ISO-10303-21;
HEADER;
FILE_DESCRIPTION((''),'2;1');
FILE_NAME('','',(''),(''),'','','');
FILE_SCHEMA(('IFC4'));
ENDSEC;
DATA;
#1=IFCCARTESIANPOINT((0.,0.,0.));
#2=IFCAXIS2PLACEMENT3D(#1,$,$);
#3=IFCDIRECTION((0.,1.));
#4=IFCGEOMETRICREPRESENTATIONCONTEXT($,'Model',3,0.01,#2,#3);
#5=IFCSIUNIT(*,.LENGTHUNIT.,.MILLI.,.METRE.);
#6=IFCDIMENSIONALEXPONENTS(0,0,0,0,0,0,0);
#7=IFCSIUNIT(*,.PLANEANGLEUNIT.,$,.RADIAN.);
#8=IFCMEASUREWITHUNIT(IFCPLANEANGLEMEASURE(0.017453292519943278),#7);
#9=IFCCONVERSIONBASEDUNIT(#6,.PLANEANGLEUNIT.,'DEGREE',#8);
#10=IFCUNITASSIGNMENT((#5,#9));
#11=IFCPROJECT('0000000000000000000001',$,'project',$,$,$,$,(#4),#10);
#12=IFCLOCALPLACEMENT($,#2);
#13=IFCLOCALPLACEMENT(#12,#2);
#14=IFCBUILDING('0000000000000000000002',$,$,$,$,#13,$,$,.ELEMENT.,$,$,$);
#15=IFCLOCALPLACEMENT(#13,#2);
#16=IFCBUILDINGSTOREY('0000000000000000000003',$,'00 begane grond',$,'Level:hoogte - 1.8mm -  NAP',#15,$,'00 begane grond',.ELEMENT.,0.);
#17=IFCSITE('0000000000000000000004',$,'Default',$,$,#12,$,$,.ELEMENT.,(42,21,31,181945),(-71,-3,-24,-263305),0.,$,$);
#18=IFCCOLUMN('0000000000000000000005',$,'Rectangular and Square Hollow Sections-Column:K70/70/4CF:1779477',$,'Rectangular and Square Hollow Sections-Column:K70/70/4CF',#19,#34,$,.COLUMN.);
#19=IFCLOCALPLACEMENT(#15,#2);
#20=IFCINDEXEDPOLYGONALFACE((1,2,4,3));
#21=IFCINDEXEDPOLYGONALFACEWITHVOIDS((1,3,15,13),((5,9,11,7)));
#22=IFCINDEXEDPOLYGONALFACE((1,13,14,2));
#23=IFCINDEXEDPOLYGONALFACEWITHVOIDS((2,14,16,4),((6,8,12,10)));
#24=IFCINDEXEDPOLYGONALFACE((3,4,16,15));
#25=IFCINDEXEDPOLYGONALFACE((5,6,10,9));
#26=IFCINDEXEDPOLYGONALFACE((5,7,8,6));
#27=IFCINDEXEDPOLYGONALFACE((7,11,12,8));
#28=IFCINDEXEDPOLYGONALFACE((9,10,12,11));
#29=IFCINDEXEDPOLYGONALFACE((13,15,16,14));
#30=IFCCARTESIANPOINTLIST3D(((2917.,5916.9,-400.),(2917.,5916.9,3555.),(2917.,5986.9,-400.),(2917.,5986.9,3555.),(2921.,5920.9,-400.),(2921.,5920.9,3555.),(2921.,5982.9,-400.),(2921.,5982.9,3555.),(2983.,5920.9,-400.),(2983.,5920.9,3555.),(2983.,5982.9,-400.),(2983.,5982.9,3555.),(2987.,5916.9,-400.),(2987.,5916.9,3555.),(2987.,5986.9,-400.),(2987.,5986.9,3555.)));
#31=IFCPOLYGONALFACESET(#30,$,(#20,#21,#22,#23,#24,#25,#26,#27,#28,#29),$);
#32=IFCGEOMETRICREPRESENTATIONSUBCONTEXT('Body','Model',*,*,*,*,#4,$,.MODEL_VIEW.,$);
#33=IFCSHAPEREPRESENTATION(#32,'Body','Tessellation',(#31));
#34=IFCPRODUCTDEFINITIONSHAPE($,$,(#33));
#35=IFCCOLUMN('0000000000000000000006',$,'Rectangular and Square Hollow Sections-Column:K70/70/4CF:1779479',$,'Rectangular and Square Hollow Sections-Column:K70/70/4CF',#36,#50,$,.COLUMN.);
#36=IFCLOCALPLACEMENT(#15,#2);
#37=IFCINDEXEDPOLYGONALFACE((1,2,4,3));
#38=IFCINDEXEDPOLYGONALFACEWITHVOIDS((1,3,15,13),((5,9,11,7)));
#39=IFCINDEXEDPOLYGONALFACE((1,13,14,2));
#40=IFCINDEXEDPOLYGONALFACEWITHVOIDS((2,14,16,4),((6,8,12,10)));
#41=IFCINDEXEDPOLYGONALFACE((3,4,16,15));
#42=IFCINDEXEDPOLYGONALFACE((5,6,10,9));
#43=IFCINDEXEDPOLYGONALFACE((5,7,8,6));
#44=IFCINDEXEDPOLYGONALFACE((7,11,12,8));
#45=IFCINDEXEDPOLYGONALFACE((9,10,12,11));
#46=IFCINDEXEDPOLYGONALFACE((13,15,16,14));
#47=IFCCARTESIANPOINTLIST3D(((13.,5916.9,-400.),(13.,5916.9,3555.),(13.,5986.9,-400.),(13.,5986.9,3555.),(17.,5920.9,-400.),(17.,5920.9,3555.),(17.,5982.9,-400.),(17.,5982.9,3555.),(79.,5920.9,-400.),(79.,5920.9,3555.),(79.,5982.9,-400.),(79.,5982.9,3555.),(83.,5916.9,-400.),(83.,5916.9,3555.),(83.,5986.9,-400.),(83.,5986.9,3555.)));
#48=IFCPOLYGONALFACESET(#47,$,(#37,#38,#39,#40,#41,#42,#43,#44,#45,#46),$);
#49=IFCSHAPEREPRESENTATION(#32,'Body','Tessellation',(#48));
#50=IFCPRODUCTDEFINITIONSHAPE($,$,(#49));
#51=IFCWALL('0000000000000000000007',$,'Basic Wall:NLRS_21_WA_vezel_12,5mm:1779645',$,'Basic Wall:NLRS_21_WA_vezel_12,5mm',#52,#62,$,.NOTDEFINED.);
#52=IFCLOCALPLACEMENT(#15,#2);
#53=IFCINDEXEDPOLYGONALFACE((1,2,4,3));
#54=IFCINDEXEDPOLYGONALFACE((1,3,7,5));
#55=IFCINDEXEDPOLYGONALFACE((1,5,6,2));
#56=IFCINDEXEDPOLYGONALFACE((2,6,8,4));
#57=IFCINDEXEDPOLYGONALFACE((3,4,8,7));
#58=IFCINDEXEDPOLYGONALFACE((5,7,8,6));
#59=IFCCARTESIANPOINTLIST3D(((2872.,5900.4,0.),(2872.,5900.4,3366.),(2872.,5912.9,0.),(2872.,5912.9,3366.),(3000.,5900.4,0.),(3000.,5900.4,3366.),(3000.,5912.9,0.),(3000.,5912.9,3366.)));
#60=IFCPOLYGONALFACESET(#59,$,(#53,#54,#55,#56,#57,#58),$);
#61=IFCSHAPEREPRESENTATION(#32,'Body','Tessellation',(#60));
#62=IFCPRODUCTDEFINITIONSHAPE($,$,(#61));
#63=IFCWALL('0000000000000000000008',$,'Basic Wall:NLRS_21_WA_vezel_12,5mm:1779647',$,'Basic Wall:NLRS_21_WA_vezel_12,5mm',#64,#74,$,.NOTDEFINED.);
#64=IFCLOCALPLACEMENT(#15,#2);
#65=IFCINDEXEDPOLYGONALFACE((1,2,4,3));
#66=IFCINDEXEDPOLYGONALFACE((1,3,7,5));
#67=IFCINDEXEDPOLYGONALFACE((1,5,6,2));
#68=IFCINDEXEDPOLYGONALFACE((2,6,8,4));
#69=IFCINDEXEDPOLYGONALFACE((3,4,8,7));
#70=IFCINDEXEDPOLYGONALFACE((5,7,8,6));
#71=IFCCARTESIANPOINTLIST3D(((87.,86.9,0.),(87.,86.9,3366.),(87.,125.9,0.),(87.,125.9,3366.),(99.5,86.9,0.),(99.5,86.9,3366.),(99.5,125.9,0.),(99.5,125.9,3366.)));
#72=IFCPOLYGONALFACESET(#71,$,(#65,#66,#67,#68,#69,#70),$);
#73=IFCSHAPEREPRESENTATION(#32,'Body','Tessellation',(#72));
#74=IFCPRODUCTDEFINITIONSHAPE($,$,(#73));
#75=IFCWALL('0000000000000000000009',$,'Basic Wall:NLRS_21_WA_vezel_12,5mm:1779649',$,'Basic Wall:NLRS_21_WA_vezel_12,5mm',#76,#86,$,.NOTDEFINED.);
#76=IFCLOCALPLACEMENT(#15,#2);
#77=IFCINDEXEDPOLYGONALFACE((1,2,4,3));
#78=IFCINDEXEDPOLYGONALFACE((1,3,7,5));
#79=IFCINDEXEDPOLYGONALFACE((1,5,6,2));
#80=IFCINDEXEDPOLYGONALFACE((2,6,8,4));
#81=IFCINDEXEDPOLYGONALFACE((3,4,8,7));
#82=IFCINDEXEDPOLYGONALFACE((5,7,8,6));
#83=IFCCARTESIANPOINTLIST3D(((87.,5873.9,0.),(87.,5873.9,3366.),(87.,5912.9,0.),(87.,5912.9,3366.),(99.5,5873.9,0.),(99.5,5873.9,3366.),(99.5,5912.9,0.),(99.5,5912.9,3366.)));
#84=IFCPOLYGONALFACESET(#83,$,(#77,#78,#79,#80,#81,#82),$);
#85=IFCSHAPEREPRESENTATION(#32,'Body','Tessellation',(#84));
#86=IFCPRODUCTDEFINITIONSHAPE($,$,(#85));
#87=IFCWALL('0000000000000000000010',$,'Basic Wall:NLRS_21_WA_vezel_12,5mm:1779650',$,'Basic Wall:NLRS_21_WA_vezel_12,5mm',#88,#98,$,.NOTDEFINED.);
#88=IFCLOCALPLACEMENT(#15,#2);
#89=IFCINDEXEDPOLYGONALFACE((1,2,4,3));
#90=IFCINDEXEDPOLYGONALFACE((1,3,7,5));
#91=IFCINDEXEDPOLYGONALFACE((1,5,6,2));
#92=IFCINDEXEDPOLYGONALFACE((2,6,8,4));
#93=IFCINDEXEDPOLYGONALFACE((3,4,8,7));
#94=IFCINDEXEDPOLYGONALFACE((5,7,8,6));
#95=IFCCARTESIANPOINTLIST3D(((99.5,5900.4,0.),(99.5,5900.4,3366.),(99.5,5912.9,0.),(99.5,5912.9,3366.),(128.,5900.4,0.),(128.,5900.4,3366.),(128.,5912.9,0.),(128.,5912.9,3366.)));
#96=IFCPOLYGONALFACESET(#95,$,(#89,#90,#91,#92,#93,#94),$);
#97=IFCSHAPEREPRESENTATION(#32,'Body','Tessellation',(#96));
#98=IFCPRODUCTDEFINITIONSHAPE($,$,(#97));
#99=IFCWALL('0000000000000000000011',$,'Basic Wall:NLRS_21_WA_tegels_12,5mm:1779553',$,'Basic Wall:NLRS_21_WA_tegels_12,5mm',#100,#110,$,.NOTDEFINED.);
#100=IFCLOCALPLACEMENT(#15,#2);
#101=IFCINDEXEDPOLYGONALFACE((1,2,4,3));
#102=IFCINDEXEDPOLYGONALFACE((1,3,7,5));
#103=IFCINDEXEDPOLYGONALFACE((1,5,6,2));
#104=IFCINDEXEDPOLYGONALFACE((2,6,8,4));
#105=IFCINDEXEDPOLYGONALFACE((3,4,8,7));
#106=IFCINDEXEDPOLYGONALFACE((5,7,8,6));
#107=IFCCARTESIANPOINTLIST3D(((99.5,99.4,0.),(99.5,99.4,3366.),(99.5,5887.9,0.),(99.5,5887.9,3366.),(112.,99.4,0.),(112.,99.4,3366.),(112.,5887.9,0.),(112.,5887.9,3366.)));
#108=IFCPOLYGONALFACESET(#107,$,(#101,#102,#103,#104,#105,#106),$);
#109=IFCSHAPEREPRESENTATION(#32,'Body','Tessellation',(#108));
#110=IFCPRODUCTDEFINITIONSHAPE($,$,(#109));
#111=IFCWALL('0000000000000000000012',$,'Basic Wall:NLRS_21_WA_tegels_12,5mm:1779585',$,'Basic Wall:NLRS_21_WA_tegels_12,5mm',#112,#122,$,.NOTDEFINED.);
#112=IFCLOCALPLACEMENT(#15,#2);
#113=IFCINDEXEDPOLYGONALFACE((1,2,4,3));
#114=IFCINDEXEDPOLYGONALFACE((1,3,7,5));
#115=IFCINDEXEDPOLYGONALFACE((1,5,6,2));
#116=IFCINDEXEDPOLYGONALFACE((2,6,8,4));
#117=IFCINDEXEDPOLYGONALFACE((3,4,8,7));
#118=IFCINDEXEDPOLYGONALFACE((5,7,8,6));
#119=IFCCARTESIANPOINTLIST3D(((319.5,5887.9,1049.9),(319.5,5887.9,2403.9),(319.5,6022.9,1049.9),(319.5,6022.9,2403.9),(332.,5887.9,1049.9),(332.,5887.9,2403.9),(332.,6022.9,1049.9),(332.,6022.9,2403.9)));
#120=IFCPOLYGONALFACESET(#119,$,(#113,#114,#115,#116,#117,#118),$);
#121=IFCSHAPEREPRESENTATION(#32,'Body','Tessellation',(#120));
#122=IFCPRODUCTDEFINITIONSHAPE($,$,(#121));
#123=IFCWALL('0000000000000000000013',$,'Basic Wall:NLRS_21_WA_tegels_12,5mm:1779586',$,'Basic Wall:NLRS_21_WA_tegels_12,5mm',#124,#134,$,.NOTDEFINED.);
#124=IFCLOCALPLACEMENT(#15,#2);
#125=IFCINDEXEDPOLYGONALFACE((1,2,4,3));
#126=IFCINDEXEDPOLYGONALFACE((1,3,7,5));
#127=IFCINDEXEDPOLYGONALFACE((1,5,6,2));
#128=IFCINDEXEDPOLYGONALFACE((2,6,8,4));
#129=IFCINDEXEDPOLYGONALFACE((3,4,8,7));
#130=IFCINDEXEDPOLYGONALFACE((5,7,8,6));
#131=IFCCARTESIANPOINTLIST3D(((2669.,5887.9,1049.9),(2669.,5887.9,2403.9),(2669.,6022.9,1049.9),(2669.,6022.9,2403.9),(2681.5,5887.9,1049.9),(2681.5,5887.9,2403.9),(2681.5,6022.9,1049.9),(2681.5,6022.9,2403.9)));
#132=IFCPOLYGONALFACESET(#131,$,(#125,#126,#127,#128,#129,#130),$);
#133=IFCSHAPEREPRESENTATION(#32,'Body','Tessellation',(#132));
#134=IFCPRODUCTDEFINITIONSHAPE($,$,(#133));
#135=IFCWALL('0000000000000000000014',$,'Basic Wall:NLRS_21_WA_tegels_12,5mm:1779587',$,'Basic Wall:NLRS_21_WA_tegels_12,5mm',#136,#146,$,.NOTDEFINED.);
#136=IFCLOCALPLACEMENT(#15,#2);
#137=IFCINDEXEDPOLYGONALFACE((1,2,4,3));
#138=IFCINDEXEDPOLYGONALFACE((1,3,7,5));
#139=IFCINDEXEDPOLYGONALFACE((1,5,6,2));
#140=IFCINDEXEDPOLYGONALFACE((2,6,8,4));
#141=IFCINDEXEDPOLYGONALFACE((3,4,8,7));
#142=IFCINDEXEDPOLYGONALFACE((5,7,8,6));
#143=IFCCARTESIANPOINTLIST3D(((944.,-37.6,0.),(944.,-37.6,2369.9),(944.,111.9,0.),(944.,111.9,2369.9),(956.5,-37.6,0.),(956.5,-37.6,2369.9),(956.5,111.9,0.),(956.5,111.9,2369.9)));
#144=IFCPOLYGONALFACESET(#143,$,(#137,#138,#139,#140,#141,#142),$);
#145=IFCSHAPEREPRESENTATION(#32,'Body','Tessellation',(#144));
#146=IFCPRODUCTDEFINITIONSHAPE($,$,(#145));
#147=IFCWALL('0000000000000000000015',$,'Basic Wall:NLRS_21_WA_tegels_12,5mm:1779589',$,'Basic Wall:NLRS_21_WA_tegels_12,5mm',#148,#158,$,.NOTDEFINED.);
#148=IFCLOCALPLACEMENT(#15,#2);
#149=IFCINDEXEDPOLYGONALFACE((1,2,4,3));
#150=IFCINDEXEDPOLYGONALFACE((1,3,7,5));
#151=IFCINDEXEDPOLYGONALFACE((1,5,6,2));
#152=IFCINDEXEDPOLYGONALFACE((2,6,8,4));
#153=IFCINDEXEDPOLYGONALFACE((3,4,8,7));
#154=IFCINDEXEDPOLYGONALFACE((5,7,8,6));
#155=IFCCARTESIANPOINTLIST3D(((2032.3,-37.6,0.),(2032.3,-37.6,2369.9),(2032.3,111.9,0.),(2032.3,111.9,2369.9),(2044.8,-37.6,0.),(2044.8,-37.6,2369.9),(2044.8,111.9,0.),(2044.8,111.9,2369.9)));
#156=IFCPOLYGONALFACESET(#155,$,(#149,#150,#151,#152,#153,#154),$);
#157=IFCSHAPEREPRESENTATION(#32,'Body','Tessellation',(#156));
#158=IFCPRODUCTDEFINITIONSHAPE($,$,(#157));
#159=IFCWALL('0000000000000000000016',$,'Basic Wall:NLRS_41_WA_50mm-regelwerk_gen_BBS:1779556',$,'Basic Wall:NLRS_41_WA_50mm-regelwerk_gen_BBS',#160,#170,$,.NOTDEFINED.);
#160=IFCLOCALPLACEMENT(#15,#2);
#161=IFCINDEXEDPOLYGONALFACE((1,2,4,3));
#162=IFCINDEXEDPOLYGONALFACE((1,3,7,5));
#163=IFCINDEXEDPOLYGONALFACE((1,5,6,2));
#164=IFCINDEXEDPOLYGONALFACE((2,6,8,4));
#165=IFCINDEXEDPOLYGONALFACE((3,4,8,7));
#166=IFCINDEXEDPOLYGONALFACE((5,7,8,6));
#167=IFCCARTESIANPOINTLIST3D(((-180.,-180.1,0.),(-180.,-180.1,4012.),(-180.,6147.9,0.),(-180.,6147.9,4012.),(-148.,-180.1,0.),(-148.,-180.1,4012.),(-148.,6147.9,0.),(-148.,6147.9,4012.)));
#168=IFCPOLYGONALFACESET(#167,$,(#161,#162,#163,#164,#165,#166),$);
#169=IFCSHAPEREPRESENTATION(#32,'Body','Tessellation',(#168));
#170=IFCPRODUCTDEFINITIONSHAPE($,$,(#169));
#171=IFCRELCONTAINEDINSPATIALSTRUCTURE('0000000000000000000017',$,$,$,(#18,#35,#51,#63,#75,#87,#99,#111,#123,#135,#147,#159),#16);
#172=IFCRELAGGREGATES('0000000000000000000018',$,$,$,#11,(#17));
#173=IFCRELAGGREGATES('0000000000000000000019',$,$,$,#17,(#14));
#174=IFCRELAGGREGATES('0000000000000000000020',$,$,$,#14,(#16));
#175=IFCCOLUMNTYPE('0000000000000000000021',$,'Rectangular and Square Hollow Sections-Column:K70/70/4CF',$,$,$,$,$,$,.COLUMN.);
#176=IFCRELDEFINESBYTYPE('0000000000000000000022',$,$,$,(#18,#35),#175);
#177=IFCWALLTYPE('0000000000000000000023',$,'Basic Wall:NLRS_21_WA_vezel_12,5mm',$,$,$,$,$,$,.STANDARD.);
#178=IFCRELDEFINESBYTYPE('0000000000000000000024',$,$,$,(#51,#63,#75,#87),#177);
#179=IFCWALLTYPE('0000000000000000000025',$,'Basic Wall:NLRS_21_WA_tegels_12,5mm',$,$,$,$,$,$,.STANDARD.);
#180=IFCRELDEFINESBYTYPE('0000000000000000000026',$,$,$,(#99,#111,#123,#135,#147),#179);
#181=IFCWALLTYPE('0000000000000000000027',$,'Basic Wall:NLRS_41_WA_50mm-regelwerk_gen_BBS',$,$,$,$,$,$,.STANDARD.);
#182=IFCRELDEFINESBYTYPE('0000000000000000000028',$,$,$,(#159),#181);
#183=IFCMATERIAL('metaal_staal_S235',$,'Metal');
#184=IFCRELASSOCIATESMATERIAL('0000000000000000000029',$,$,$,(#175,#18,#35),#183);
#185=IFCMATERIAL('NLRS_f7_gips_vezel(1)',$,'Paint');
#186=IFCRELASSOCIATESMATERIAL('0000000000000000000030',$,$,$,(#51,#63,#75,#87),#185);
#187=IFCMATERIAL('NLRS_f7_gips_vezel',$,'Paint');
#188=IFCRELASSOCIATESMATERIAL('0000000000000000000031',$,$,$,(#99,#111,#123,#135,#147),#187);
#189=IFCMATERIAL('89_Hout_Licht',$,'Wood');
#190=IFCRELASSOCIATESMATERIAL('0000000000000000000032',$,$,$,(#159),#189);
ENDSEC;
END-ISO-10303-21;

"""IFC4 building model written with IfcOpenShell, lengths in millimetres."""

from ifc_helpers import new_model, entity, si_unit, converted_unit, direction, frame, origin, place, context, subcontext, project, spatial, indexed_curve, outline, extrude, source, transform, mapped, material, type_object, type_shapes, element, save


model = new_model("IFC4")

# Units and contexts
model_context = context("Model", 3, precision=0.01, world=origin(), true_north=direction((0.0, 1.0)))
body_context = subcontext(model_context, "Body", "Model", "MODEL_VIEW")
ifc_project = project(units=[si_unit("LENGTHUNIT", "METRE", prefix="MILLI"), converted_unit("PLANEANGLEUNIT", "DEGREE", entity("IfcPlaneAngleMeasure", 0.017453292519943278), si_unit("PLANEANGLEUNIT", "RADIAN"), dimensions=[0, 0, 0, 0, 0, 0, 0])], contexts=[model_context])

# Site, building, storey
site_placement = place(None, origin())
site = spatial("IfcSite", under=ifc_project, at=site_placement, Name="Default", CompositionType="ELEMENT", RefLatitude=(42, 21, 31, 181945), RefLongitude=(-71, -3, -24, -263305), RefElevation=0.0)
building_placement = place(site_placement, origin())
building = spatial("IfcBuilding", under=site, at=building_placement, CompositionType="ELEMENT")
storey_placement = place(building_placement, origin())
storey = spatial("IfcBuildingStorey", under=building, at=storey_placement, Name="00 begane grond", ObjectType="Level:hoogte - 1.8mm -  NAP", LongName="00 begane grond", CompositionType="ELEMENT", Elevation=0.0)

# Columns
ifc_material_1 = material(Name="metaal_staal_S235", Category="Metal")
column_type = type_object("IfcColumnType", Name="Rectangular and Square Hollow Sections-Column:K70/70/4CF", PredefinedType="COLUMN", material=ifc_material_1)
shared_shape_1 = source(origin(), body_context, "Body", "SweptSolid", [
    extrude(outline(indexed_curve([(-35.0, -35.0), (35.0, -35.0), (35.0, 35.0), (-35.0, 35.0), (-35.0, -35.0)], self_intersect=False), holes=[indexed_curve([(-31.0, -31.0), (-31.0, 31.0), (31.0, 31.0), (31.0, -31.0), (-31.0, -31.0)], self_intersect=False)]), frame((0.0, 0.0, -400.0), z_axis=(0.0, 0.0, 1.0), x_axis=(0.0, 1.0, 0.0)), (0.0, 0.0, 1.0), 3955.0),
])
type_shapes(column_type, [shared_shape_1])
for number, where, z_axis, x_axis, name in (
    (1, (2952.0, 5951.9, 0.0), (0.0, 0.0, 1.0), (0.0, 1.0, 0.0), "Rectangular and Square Hollow Sections-Column:K70/70/4CF:1779477"),
    (2, (48.0, 5951.9, 0.0), (0.0, 0.0, 1.0), (0.0, 1.0, 0.0), "Rectangular and Square Hollow Sections-Column:K70/70/4CF:1779479"),
):
    element("IfcColumn", number, at=place(storey_placement, frame(where, z_axis=z_axis, x_axis=x_axis)), inside=storey, type_object=column_type, material=ifc_material_1, Name=name, ObjectType="Rectangular and Square Hollow Sections-Column:K70/70/4CF", PredefinedType="COLUMN", context=body_context, shape_type="MappedRepresentation", body=[
        mapped(shared_shape_1, transform((0.0, 0.0, 0.0), scale=1.0)),
    ])

# Walls
ifc_material_2 = material(Name="NLRS_f7_gips_vezel(1)", Category="Paint")
wall_type_1 = type_object("IfcWallType", Name="Basic Wall:NLRS_21_WA_vezel_12,5mm", PredefinedType="STANDARD")
wall_1_placement = place(storey_placement, frame((2872.0, 5906.7, 0.0)))
element("IfcWall", 3, at=wall_1_placement, inside=storey, type_object=wall_type_1, material=ifc_material_2, Name="Basic Wall:NLRS_21_WA_vezel_12,5mm:1779645", ObjectType="Basic Wall:NLRS_21_WA_vezel_12,5mm", PredefinedType="NOTDEFINED", context=body_context, shape_type="SweptSolid", body=[
    extrude(outline(indexed_curve([(128.0, 6.2), (0.0, 6.2), (0.0, -6.2), (128.0, -6.2), (128.0, 6.2)], self_intersect=False)), origin(), (0.0, 0.0, 1.0), 3366.0),
])
wall_2_placement = place(storey_placement, frame((93.2, 125.9, 0.0), z_axis=(0.0, 0.0, 1.0), x_axis=(0.0, -1.0, 0.0)))
element("IfcWall", 4, at=wall_2_placement, inside=storey, type_object=wall_type_1, material=ifc_material_2, Name="Basic Wall:NLRS_21_WA_vezel_12,5mm:1779647", ObjectType="Basic Wall:NLRS_21_WA_vezel_12,5mm", PredefinedType="NOTDEFINED", context=body_context, shape_type="SweptSolid", body=[
    extrude(outline(indexed_curve([(39.0, 6.2), (0.0, 6.2), (0.0, -6.2), (39.0, -6.2), (39.0, 6.2)], self_intersect=False)), origin(), (0.0, 0.0, 1.0), 3366.0),
])
wall_3_placement = place(storey_placement, frame((93.2, 5873.9, 0.0), z_axis=(0.0, 0.0, 1.0), x_axis=(0.0, 1.0, 0.0)))
element("IfcWall", 5, at=wall_3_placement, inside=storey, type_object=wall_type_1, material=ifc_material_2, Name="Basic Wall:NLRS_21_WA_vezel_12,5mm:1779649", ObjectType="Basic Wall:NLRS_21_WA_vezel_12,5mm", PredefinedType="NOTDEFINED", context=body_context, shape_type="SweptSolid", body=[
    extrude(outline(indexed_curve([(39.0, 6.3), (0.0, 6.2), (0.0, -6.2), (39.0, -6.2), (39.0, 6.3)], self_intersect=False)), origin(), (0.0, 0.0, 1.0), 3366.0),
])
wall_4_placement = place(storey_placement, frame((99.5, 5906.7, 0.0)))
element("IfcWall", 6, at=wall_4_placement, inside=storey, type_object=wall_type_1, material=ifc_material_2, Name="Basic Wall:NLRS_21_WA_vezel_12,5mm:1779650", ObjectType="Basic Wall:NLRS_21_WA_vezel_12,5mm", PredefinedType="NOTDEFINED", context=body_context, shape_type="SweptSolid", body=[
    extrude(outline(indexed_curve([(28.5, 6.2), (0.0, 6.2), (0.0, -6.2), (28.5, -6.2), (28.5, 6.2)], self_intersect=False)), origin(), (0.0, 0.0, 1.0), 3366.0),
])
ifc_material_3 = material(Name="NLRS_f7_gips_vezel", Category="Paint")
wall_type_2 = type_object("IfcWallType", Name="Basic Wall:NLRS_21_WA_tegels_12,5mm", PredefinedType="STANDARD")
wall_5_placement = place(storey_placement, frame((105.7, 5887.9, 0.0), z_axis=(0.0, 0.0, 1.0), x_axis=(0.0, -1.0, 0.0)))
element("IfcWall", 7, at=wall_5_placement, inside=storey, type_object=wall_type_2, material=ifc_material_3, Name="Basic Wall:NLRS_21_WA_tegels_12,5mm:1779553", ObjectType="Basic Wall:NLRS_21_WA_tegels_12,5mm", PredefinedType="NOTDEFINED", context=body_context, shape_type="SweptSolid", body=[
    extrude(outline(indexed_curve([(5788.5, 6.2), (0.0, 6.2), (0.0, -6.2), (5788.5, -6.3), (5788.5, 6.2)], self_intersect=False)), origin(), (0.0, 0.0, 1.0), 3366.0),
])
wall_6_placement = place(storey_placement, frame((325.7, 5887.9, 1049.9), z_axis=(0.0, 0.0, 1.0), x_axis=(0.0, 1.0, 0.0)))
element("IfcWall", 8, at=wall_6_placement, inside=storey, type_object=wall_type_2, material=ifc_material_3, Name="Basic Wall:NLRS_21_WA_tegels_12,5mm:1779585", ObjectType="Basic Wall:NLRS_21_WA_tegels_12,5mm", PredefinedType="NOTDEFINED", context=body_context, shape_type="SweptSolid", body=[
    extrude(outline(indexed_curve([(135.0, 6.2), (0.0, 6.2), (0.0, -6.2), (135.0, -6.2), (135.0, 6.2)], self_intersect=False)), origin(), (0.0, 0.0, 1.0), 1354.0),
])
wall_7_placement = place(storey_placement, frame((2675.2, 5887.9, 1049.9), z_axis=(0.0, 0.0, 1.0), x_axis=(0.0, 1.0, 0.0)))
element("IfcWall", 9, at=wall_7_placement, inside=storey, type_object=wall_type_2, material=ifc_material_3, Name="Basic Wall:NLRS_21_WA_tegels_12,5mm:1779586", ObjectType="Basic Wall:NLRS_21_WA_tegels_12,5mm", PredefinedType="NOTDEFINED", context=body_context, shape_type="SweptSolid", body=[
    extrude(outline(indexed_curve([(135.0, 6.2), (0.0, 6.3), (0.0, -6.3), (135.0, -6.3), (135.0, 6.2)], self_intersect=False)), origin(), (0.0, 0.0, 1.0), 1354.0),
])
wall_8_placement = place(storey_placement, frame((950.2, 111.9, 0.0), z_axis=(0.0, 0.0, 1.0), x_axis=(0.0, -1.0, 0.0)))
element("IfcWall", 10, at=wall_8_placement, inside=storey, type_object=wall_type_2, material=ifc_material_3, Name="Basic Wall:NLRS_21_WA_tegels_12,5mm:1779587", ObjectType="Basic Wall:NLRS_21_WA_tegels_12,5mm", PredefinedType="NOTDEFINED", context=body_context, shape_type="SweptSolid", body=[
    extrude(outline(indexed_curve([(149.5, 6.2), (0.0, 6.2), (0.0, -6.2), (149.5, -6.2), (149.5, 6.2)], self_intersect=False)), origin(), (0.0, 0.0, 1.0), 2369.9),
])
wall_9_placement = place(storey_placement, frame((2038.6, 111.9, 0.0), z_axis=(0.0, 0.0, 1.0), x_axis=(0.0, -1.0, 0.0)))
element("IfcWall", 11, at=wall_9_placement, inside=storey, type_object=wall_type_2, material=ifc_material_3, Name="Basic Wall:NLRS_21_WA_tegels_12,5mm:1779589", ObjectType="Basic Wall:NLRS_21_WA_tegels_12,5mm", PredefinedType="NOTDEFINED", context=body_context, shape_type="SweptSolid", body=[
    extrude(outline(indexed_curve([(149.5, 6.2), (0.0, 6.2), (0.0, -6.2), (149.5, -6.2), (149.5, 6.2)], self_intersect=False)), origin(), (0.0, 0.0, 1.0), 2369.9),
])
ifc_material_4 = material(Name="89_Hout_Licht", Category="Wood")
wall_type_3 = type_object("IfcWallType", Name="Basic Wall:NLRS_41_WA_50mm-regelwerk_gen_BBS", PredefinedType="STANDARD")
wall_10_placement = place(storey_placement, frame((-164.0, 6147.9, 0.0), z_axis=(0.0, 0.0, 1.0), x_axis=(0.0, -1.0, 0.0)))
element("IfcWall", 12, at=wall_10_placement, inside=storey, type_object=wall_type_3, material=ifc_material_4, Name="Basic Wall:NLRS_41_WA_50mm-regelwerk_gen_BBS:1779556", ObjectType="Basic Wall:NLRS_41_WA_50mm-regelwerk_gen_BBS", PredefinedType="NOTDEFINED", context=body_context, shape_type="SweptSolid", body=[
    extrude(outline(indexed_curve([(6328.0, 16.0), (0.0, 16.0), (0.0, -16.0), (6328.0, -16.0), (6328.0, 16.0)], self_intersect=False)), origin(), (0.0, 0.0, 1.0), 4012.0),
])

save(model, "model.ifc")
